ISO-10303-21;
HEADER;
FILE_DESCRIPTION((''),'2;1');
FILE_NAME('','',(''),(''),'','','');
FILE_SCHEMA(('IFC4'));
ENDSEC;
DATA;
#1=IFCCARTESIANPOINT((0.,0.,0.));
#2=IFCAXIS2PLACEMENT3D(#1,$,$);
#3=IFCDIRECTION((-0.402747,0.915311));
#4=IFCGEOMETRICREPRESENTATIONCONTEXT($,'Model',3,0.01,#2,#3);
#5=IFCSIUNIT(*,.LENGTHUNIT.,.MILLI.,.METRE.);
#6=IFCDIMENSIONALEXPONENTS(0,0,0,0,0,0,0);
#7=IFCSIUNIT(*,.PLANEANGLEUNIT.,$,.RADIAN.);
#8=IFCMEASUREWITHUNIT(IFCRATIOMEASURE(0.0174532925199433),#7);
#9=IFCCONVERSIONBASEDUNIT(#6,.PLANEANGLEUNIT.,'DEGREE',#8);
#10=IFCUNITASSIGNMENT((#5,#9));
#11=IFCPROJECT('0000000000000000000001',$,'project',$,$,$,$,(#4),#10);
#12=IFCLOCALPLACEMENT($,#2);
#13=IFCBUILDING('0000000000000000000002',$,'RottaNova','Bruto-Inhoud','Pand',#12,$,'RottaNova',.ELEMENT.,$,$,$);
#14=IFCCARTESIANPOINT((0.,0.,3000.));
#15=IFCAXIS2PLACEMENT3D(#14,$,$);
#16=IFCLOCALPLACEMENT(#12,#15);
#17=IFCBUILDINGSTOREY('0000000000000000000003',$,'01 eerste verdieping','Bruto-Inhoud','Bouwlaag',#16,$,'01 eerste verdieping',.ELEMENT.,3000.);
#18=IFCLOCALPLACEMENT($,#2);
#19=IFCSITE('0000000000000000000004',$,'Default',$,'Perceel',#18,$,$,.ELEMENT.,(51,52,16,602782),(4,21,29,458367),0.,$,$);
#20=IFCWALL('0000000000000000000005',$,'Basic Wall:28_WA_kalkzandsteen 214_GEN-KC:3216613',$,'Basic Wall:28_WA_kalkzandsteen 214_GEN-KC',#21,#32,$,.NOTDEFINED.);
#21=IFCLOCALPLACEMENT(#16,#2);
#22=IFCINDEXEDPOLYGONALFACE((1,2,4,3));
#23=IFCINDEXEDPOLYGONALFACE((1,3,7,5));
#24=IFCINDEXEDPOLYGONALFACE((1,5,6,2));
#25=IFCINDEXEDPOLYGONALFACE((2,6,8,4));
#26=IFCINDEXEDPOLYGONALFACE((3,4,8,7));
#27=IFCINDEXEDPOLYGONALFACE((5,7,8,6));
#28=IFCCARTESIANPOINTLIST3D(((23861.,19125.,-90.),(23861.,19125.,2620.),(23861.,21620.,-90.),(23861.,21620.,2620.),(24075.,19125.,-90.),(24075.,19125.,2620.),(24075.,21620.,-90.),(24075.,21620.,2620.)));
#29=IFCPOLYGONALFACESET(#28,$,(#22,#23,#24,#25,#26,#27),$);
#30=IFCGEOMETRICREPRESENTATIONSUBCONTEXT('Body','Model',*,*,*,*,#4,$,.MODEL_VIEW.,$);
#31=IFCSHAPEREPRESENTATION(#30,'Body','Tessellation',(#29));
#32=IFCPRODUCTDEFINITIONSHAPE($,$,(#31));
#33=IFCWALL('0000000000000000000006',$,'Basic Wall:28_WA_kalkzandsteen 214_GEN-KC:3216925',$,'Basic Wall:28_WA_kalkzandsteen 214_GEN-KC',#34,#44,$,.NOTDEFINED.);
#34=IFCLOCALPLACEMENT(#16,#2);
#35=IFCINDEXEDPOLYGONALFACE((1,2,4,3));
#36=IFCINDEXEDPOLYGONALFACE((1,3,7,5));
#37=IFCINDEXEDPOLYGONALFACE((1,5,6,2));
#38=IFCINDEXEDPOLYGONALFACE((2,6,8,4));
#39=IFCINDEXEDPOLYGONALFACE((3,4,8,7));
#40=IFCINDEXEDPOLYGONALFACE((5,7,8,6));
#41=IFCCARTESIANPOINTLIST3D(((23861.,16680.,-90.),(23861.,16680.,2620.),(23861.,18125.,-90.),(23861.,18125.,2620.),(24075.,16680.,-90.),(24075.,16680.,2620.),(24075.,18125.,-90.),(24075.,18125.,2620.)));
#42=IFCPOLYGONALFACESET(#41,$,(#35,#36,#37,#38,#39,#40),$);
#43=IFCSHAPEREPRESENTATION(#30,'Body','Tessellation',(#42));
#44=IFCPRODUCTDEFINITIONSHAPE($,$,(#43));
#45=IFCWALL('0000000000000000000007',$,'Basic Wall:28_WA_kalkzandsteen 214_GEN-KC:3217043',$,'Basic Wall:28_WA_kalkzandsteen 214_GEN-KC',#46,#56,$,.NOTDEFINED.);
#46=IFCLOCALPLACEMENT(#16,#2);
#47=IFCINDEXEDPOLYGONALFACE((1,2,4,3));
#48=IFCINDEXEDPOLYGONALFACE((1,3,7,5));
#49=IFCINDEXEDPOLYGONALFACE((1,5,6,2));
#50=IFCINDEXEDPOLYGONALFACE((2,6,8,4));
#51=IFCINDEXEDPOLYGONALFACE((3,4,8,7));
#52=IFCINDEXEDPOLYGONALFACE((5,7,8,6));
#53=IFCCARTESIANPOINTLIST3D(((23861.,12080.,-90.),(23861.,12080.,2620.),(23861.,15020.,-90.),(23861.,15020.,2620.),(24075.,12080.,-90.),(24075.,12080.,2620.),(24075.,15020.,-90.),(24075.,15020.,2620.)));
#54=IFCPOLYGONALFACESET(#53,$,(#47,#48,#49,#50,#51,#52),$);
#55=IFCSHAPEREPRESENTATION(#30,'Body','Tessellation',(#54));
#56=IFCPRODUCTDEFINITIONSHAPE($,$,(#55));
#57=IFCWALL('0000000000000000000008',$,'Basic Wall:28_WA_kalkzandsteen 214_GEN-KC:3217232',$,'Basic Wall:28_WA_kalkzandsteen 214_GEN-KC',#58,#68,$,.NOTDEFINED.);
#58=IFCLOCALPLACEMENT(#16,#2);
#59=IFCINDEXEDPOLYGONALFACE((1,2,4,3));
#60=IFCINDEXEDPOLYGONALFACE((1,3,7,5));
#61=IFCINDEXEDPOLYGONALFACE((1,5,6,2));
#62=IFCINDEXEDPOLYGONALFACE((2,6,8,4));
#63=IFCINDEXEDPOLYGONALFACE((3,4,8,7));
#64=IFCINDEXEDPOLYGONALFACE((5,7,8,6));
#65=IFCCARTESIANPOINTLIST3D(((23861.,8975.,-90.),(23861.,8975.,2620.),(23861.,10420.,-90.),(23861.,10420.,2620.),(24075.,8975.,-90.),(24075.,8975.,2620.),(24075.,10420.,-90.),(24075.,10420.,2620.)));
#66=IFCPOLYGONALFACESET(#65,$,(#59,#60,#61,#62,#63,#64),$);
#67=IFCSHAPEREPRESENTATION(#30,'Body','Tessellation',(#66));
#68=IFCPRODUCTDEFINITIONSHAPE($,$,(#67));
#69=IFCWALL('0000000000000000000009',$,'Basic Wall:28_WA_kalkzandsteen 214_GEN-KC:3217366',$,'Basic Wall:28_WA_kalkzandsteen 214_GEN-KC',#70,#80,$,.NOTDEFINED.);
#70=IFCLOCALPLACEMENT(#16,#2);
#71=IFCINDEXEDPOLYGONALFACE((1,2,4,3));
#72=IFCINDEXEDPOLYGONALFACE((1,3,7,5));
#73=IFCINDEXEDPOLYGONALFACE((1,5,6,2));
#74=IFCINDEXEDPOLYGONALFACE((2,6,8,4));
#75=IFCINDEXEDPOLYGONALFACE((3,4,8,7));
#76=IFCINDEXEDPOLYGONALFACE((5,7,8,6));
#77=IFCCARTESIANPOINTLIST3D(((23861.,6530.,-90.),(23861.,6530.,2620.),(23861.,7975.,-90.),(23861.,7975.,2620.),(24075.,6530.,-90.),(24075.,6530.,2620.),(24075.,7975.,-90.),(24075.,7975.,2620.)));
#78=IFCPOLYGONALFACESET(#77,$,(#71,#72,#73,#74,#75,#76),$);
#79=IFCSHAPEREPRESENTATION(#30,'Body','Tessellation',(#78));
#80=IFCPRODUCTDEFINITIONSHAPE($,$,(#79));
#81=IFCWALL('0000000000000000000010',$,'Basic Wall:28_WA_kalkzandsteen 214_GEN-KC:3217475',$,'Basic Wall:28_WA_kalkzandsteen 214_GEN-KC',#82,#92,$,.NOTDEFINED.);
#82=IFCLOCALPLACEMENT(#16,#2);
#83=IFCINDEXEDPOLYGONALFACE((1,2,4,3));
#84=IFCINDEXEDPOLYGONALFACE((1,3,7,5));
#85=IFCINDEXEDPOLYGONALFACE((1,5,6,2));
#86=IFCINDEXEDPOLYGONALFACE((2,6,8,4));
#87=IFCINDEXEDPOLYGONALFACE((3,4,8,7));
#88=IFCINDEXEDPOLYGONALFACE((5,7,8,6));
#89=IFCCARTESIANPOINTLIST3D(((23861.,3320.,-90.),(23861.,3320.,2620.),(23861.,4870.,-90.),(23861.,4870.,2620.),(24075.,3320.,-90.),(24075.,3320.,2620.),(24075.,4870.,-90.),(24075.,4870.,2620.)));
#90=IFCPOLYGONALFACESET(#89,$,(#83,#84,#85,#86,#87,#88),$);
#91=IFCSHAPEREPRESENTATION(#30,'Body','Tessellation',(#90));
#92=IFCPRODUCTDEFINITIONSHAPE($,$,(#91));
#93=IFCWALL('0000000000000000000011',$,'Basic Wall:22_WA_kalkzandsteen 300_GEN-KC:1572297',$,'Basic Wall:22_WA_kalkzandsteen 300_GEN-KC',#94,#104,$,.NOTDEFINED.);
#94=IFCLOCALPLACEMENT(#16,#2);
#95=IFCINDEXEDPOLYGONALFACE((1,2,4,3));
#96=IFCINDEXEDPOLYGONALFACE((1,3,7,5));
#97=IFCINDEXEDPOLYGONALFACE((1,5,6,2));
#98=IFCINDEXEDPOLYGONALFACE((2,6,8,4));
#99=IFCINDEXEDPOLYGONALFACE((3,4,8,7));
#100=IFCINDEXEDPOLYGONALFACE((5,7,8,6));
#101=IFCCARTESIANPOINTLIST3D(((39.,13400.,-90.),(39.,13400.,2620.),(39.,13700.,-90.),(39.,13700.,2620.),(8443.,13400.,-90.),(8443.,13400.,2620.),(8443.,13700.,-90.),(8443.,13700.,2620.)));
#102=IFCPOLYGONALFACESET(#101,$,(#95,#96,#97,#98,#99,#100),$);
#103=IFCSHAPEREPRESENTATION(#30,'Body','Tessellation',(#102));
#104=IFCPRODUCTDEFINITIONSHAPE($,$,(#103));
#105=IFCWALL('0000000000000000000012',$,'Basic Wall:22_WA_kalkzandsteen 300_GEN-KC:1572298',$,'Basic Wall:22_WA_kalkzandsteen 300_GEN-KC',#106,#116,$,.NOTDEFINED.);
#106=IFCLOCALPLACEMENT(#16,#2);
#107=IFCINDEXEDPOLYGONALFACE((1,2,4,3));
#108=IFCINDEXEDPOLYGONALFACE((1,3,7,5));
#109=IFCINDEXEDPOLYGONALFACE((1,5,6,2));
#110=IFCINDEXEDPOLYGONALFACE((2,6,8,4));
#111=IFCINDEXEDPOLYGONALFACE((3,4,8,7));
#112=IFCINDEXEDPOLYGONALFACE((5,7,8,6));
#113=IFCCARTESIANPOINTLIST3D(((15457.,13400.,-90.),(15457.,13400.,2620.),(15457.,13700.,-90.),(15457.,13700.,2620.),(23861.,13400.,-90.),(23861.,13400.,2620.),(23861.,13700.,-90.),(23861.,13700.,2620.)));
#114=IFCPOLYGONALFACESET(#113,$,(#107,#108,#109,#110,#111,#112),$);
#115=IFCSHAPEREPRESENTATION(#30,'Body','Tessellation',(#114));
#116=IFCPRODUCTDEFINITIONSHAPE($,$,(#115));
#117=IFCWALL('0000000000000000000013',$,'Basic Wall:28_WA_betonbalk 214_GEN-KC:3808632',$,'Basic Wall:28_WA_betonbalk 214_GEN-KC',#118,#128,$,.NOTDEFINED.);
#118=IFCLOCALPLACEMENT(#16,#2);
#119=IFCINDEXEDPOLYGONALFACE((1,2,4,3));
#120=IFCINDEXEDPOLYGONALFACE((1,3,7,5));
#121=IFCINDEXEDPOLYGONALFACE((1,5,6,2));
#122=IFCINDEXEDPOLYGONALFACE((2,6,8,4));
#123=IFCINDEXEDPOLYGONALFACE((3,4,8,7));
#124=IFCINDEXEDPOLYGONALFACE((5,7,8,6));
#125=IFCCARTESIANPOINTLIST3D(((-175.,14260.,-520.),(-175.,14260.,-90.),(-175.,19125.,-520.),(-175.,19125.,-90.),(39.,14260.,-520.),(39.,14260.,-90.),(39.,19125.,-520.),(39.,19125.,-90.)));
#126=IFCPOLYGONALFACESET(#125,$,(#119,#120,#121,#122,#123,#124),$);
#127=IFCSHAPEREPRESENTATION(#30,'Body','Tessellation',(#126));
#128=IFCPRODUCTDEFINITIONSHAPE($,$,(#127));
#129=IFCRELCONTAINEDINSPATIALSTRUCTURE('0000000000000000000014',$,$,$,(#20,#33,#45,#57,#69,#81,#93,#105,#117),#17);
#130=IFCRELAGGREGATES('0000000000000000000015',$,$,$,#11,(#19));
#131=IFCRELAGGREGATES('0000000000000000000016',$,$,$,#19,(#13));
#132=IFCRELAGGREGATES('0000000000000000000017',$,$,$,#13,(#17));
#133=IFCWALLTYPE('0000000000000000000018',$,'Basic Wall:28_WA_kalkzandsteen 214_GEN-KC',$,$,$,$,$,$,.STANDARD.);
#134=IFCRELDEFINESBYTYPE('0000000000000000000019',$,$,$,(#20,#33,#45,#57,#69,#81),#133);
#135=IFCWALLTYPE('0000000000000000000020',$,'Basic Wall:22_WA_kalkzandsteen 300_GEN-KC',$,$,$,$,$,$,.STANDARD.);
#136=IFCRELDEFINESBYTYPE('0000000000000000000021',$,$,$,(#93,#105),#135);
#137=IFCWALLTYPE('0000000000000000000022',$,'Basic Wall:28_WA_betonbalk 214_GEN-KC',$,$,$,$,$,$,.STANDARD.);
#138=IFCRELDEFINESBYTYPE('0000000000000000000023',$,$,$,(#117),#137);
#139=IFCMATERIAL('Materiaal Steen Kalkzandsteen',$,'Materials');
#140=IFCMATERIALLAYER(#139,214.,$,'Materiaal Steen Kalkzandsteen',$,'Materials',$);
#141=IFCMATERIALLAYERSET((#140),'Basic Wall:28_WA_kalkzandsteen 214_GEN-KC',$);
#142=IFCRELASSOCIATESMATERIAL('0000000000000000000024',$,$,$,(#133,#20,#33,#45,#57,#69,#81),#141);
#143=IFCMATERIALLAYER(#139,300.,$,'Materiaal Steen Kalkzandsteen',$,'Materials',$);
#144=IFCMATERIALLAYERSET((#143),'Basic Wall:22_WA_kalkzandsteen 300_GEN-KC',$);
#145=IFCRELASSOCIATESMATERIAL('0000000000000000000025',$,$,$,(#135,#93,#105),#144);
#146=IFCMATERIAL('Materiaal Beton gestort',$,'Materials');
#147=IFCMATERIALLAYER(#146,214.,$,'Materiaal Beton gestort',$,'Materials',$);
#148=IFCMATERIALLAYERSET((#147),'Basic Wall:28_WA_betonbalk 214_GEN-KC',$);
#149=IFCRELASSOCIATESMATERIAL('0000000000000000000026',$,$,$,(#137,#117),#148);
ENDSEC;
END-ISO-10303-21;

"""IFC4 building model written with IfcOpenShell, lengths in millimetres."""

from ifc_helpers import new_model, entity, si_unit, converted_unit, direction, frame, frame_2d, origin, place, context, subcontext, project, spatial, rectangle, extrude, material, layer, layer_set, type_object, element, save


model = new_model("IFC4")

# Units and contexts
model_context = context("Model", 3, precision=0.01, world=origin(), true_north=direction((-0.402747, 0.915311)))
body_context = subcontext(model_context, "Body", "Model", "MODEL_VIEW")
ifc_project = project(units=[si_unit("LENGTHUNIT", "METRE", prefix="MILLI"), converted_unit("PLANEANGLEUNIT", "DEGREE", entity("IfcRatioMeasure", 0.0174532925199433), si_unit("PLANEANGLEUNIT", "RADIAN"), dimensions=[0, 0, 0, 0, 0, 0, 0])], contexts=[model_context])

# Site, building, storey
site_placement = place(None, origin())
site = spatial("IfcSite", under=ifc_project, at=site_placement, Name="Default", ObjectType="Perceel", CompositionType="ELEMENT", RefLatitude=(51, 52, 16, 602782), RefLongitude=(4, 21, 29, 458367), RefElevation=0.0)
building_placement = place(None, origin())
building = spatial("IfcBuilding", under=site, at=building_placement, Name="RottaNova", Description="Bruto-Inhoud", ObjectType="Pand", LongName="RottaNova", CompositionType="ELEMENT")
storey_placement = place(building_placement, frame((0.0, 0.0, 3000.0)))
storey = spatial("IfcBuildingStorey", under=building, at=storey_placement, Name="01 eerste verdieping", Description="Bruto-Inhoud", ObjectType="Bouwlaag", LongName="01 eerste verdieping", CompositionType="ELEMENT", Elevation=3000.0)

# Walls
ifc_material_1 = material(Name="Materiaal Steen Kalkzandsteen", Category="Materials")
ifc_layer_1 = layer(ifc_material_1, 214.0, Name="Materiaal Steen Kalkzandsteen", Category="Materials")
ifc_layer_set_1 = layer_set([ifc_layer_1], Name="Basic Wall:28_WA_kalkzandsteen 214_GEN-KC")
wall_type_1 = type_object("IfcWallType", Name="Basic Wall:28_WA_kalkzandsteen 214_GEN-KC", PredefinedType="STANDARD", material=ifc_layer_set_1)
wall_1_placement = place(storey_placement, frame((23968.0, 21620.0, -90.0), z_axis=(0.0, 0.0, 1.0), x_axis=(0.0, -1.0, 0.0)))
element("IfcWall", 1, at=wall_1_placement, inside=storey, type_object=wall_type_1, material=ifc_layer_set_1, Name="Basic Wall:28_WA_kalkzandsteen 214_GEN-KC:3216613", ObjectType="Basic Wall:28_WA_kalkzandsteen 214_GEN-KC", PredefinedType="NOTDEFINED", context=body_context, shape_type="SweptSolid", body=[
    extrude(rectangle(XDim=2495.0, YDim=214.0, at=frame_2d((1247.5, 0.0), x_axis=(-1.0, 0.0))), origin(), (0.0, 0.0, 1.0), 2710.0),
])
wall_2_placement = place(storey_placement, frame((23968.0, 18125.0, -90.0), z_axis=(0.0, 0.0, 1.0), x_axis=(0.0, -1.0, 0.0)))
element("IfcWall", 2, at=wall_2_placement, inside=storey, type_object=wall_type_1, material=ifc_layer_set_1, Name="Basic Wall:28_WA_kalkzandsteen 214_GEN-KC:3216925", ObjectType="Basic Wall:28_WA_kalkzandsteen 214_GEN-KC", PredefinedType="NOTDEFINED", context=body_context, shape_type="SweptSolid", body=[
    extrude(rectangle(XDim=1445.0, YDim=214.0, at=frame_2d((722.5, 0.0), x_axis=(-1.0, 0.0))), origin(), (0.0, 0.0, 1.0), 2710.0),
])
wall_3_placement = place(storey_placement, frame((23968.0, 15020.0, -90.0), z_axis=(0.0, 0.0, 1.0), x_axis=(0.0, -1.0, 0.0)))
element("IfcWall", 3, at=wall_3_placement, inside=storey, type_object=wall_type_1, material=ifc_layer_set_1, Name="Basic Wall:28_WA_kalkzandsteen 214_GEN-KC:3217043", ObjectType="Basic Wall:28_WA_kalkzandsteen 214_GEN-KC", PredefinedType="NOTDEFINED", context=body_context, shape_type="SweptSolid", body=[
    extrude(rectangle(XDim=2940.0, YDim=214.0, at=frame_2d((1470.0, 0.0), x_axis=(-1.0, 0.0))), origin(), (0.0, 0.0, 1.0), 2710.0),
])
wall_4_placement = place(storey_placement, frame((23968.0, 10420.0, -90.0), z_axis=(0.0, 0.0, 1.0), x_axis=(0.0, -1.0, 0.0)))
element("IfcWall", 4, at=wall_4_placement, inside=storey, type_object=wall_type_1, material=ifc_layer_set_1, Name="Basic Wall:28_WA_kalkzandsteen 214_GEN-KC:3217232", ObjectType="Basic Wall:28_WA_kalkzandsteen 214_GEN-KC", PredefinedType="NOTDEFINED", context=body_context, shape_type="SweptSolid", body=[
    extrude(rectangle(XDim=1445.0, YDim=214.0, at=frame_2d((722.5, 0.0), x_axis=(-1.0, 0.0))), origin(), (0.0, 0.0, 1.0), 2710.0),
])
wall_5_placement = place(storey_placement, frame((23968.0, 7975.0, -90.0), z_axis=(0.0, 0.0, 1.0), x_axis=(0.0, -1.0, 0.0)))
element("IfcWall", 5, at=wall_5_placement, inside=storey, type_object=wall_type_1, material=ifc_layer_set_1, Name="Basic Wall:28_WA_kalkzandsteen 214_GEN-KC:3217366", ObjectType="Basic Wall:28_WA_kalkzandsteen 214_GEN-KC", PredefinedType="NOTDEFINED", context=body_context, shape_type="SweptSolid", body=[
    extrude(rectangle(XDim=1445.0, YDim=214.0, at=frame_2d((722.5, 0.0), x_axis=(-1.0, 0.0))), origin(), (0.0, 0.0, 1.0), 2710.0),
])
wall_6_placement = place(storey_placement, frame((23968.0, 4870.0, -90.0), z_axis=(0.0, 0.0, 1.0), x_axis=(0.0, -1.0, 0.0)))
element("IfcWall", 6, at=wall_6_placement, inside=storey, type_object=wall_type_1, material=ifc_layer_set_1, Name="Basic Wall:28_WA_kalkzandsteen 214_GEN-KC:3217475", ObjectType="Basic Wall:28_WA_kalkzandsteen 214_GEN-KC", PredefinedType="NOTDEFINED", context=body_context, shape_type="SweptSolid", body=[
    extrude(rectangle(XDim=1550.0, YDim=214.0, at=frame_2d((775.0, 0.0), x_axis=(-1.0, 0.0))), origin(), (0.0, 0.0, 1.0), 2710.0),
])
ifc_layer_2 = layer(ifc_material_1, 300.0, Name="Materiaal Steen Kalkzandsteen", Category="Materials")
ifc_layer_set_2 = layer_set([ifc_layer_2], Name="Basic Wall:22_WA_kalkzandsteen 300_GEN-KC")
wall_type_2 = type_object("IfcWallType", Name="Basic Wall:22_WA_kalkzandsteen 300_GEN-KC", PredefinedType="STANDARD", material=ifc_layer_set_2)
wall_7_placement = place(storey_placement, frame((39.0, 13550.0, -90.0)))
element("IfcWall", 7, at=wall_7_placement, inside=storey, type_object=wall_type_2, material=ifc_layer_set_2, Name="Basic Wall:22_WA_kalkzandsteen 300_GEN-KC:1572297", ObjectType="Basic Wall:22_WA_kalkzandsteen 300_GEN-KC", PredefinedType="NOTDEFINED", context=body_context, shape_type="SweptSolid", body=[
    extrude(rectangle(XDim=8404.0, YDim=300.0, at=frame_2d((4202.0, 0.0), x_axis=(-1.0, 0.0))), origin(), (0.0, 0.0, 1.0), 2710.0),
])
wall_8_placement = place(storey_placement, frame((15457.0, 13550.0, -90.0)))
element("IfcWall", 8, at=wall_8_placement, inside=storey, type_object=wall_type_2, material=ifc_layer_set_2, Name="Basic Wall:22_WA_kalkzandsteen 300_GEN-KC:1572298", ObjectType="Basic Wall:22_WA_kalkzandsteen 300_GEN-KC", PredefinedType="NOTDEFINED", context=body_context, shape_type="SweptSolid", body=[
    extrude(rectangle(XDim=8404.0, YDim=300.0, at=frame_2d((4202.0, 0.0), x_axis=(-1.0, 0.0))), origin(), (0.0, 0.0, 1.0), 2710.0),
])
ifc_material_2 = material(Name="Materiaal Beton gestort", Category="Materials")
ifc_layer_3 = layer(ifc_material_2, 214.0, Name="Materiaal Beton gestort", Category="Materials")
ifc_layer_set_3 = layer_set([ifc_layer_3], Name="Basic Wall:28_WA_betonbalk 214_GEN-KC")
wall_type_3 = type_object("IfcWallType", Name="Basic Wall:28_WA_betonbalk 214_GEN-KC", PredefinedType="STANDARD", material=ifc_layer_set_3)
wall_9_placement = place(storey_placement, frame((-68.0, 14260.0, -520.0), z_axis=(0.0, 0.0, 1.0), x_axis=(0.0, 1.0, 0.0)))
element("IfcWall", 9, at=wall_9_placement, inside=storey, type_object=wall_type_3, material=ifc_layer_set_3, Name="Basic Wall:28_WA_betonbalk 214_GEN-KC:3808632", ObjectType="Basic Wall:28_WA_betonbalk 214_GEN-KC", PredefinedType="NOTDEFINED", context=body_context, shape_type="SweptSolid", body=[
    extrude(rectangle(XDim=4865.0, YDim=214.0, at=frame_2d((2432.5, 0.0), x_axis=(-1.0, 0.0))), origin(), (0.0, 0.0, 1.0), 430.0),
])

save(model, "model.ifc")
